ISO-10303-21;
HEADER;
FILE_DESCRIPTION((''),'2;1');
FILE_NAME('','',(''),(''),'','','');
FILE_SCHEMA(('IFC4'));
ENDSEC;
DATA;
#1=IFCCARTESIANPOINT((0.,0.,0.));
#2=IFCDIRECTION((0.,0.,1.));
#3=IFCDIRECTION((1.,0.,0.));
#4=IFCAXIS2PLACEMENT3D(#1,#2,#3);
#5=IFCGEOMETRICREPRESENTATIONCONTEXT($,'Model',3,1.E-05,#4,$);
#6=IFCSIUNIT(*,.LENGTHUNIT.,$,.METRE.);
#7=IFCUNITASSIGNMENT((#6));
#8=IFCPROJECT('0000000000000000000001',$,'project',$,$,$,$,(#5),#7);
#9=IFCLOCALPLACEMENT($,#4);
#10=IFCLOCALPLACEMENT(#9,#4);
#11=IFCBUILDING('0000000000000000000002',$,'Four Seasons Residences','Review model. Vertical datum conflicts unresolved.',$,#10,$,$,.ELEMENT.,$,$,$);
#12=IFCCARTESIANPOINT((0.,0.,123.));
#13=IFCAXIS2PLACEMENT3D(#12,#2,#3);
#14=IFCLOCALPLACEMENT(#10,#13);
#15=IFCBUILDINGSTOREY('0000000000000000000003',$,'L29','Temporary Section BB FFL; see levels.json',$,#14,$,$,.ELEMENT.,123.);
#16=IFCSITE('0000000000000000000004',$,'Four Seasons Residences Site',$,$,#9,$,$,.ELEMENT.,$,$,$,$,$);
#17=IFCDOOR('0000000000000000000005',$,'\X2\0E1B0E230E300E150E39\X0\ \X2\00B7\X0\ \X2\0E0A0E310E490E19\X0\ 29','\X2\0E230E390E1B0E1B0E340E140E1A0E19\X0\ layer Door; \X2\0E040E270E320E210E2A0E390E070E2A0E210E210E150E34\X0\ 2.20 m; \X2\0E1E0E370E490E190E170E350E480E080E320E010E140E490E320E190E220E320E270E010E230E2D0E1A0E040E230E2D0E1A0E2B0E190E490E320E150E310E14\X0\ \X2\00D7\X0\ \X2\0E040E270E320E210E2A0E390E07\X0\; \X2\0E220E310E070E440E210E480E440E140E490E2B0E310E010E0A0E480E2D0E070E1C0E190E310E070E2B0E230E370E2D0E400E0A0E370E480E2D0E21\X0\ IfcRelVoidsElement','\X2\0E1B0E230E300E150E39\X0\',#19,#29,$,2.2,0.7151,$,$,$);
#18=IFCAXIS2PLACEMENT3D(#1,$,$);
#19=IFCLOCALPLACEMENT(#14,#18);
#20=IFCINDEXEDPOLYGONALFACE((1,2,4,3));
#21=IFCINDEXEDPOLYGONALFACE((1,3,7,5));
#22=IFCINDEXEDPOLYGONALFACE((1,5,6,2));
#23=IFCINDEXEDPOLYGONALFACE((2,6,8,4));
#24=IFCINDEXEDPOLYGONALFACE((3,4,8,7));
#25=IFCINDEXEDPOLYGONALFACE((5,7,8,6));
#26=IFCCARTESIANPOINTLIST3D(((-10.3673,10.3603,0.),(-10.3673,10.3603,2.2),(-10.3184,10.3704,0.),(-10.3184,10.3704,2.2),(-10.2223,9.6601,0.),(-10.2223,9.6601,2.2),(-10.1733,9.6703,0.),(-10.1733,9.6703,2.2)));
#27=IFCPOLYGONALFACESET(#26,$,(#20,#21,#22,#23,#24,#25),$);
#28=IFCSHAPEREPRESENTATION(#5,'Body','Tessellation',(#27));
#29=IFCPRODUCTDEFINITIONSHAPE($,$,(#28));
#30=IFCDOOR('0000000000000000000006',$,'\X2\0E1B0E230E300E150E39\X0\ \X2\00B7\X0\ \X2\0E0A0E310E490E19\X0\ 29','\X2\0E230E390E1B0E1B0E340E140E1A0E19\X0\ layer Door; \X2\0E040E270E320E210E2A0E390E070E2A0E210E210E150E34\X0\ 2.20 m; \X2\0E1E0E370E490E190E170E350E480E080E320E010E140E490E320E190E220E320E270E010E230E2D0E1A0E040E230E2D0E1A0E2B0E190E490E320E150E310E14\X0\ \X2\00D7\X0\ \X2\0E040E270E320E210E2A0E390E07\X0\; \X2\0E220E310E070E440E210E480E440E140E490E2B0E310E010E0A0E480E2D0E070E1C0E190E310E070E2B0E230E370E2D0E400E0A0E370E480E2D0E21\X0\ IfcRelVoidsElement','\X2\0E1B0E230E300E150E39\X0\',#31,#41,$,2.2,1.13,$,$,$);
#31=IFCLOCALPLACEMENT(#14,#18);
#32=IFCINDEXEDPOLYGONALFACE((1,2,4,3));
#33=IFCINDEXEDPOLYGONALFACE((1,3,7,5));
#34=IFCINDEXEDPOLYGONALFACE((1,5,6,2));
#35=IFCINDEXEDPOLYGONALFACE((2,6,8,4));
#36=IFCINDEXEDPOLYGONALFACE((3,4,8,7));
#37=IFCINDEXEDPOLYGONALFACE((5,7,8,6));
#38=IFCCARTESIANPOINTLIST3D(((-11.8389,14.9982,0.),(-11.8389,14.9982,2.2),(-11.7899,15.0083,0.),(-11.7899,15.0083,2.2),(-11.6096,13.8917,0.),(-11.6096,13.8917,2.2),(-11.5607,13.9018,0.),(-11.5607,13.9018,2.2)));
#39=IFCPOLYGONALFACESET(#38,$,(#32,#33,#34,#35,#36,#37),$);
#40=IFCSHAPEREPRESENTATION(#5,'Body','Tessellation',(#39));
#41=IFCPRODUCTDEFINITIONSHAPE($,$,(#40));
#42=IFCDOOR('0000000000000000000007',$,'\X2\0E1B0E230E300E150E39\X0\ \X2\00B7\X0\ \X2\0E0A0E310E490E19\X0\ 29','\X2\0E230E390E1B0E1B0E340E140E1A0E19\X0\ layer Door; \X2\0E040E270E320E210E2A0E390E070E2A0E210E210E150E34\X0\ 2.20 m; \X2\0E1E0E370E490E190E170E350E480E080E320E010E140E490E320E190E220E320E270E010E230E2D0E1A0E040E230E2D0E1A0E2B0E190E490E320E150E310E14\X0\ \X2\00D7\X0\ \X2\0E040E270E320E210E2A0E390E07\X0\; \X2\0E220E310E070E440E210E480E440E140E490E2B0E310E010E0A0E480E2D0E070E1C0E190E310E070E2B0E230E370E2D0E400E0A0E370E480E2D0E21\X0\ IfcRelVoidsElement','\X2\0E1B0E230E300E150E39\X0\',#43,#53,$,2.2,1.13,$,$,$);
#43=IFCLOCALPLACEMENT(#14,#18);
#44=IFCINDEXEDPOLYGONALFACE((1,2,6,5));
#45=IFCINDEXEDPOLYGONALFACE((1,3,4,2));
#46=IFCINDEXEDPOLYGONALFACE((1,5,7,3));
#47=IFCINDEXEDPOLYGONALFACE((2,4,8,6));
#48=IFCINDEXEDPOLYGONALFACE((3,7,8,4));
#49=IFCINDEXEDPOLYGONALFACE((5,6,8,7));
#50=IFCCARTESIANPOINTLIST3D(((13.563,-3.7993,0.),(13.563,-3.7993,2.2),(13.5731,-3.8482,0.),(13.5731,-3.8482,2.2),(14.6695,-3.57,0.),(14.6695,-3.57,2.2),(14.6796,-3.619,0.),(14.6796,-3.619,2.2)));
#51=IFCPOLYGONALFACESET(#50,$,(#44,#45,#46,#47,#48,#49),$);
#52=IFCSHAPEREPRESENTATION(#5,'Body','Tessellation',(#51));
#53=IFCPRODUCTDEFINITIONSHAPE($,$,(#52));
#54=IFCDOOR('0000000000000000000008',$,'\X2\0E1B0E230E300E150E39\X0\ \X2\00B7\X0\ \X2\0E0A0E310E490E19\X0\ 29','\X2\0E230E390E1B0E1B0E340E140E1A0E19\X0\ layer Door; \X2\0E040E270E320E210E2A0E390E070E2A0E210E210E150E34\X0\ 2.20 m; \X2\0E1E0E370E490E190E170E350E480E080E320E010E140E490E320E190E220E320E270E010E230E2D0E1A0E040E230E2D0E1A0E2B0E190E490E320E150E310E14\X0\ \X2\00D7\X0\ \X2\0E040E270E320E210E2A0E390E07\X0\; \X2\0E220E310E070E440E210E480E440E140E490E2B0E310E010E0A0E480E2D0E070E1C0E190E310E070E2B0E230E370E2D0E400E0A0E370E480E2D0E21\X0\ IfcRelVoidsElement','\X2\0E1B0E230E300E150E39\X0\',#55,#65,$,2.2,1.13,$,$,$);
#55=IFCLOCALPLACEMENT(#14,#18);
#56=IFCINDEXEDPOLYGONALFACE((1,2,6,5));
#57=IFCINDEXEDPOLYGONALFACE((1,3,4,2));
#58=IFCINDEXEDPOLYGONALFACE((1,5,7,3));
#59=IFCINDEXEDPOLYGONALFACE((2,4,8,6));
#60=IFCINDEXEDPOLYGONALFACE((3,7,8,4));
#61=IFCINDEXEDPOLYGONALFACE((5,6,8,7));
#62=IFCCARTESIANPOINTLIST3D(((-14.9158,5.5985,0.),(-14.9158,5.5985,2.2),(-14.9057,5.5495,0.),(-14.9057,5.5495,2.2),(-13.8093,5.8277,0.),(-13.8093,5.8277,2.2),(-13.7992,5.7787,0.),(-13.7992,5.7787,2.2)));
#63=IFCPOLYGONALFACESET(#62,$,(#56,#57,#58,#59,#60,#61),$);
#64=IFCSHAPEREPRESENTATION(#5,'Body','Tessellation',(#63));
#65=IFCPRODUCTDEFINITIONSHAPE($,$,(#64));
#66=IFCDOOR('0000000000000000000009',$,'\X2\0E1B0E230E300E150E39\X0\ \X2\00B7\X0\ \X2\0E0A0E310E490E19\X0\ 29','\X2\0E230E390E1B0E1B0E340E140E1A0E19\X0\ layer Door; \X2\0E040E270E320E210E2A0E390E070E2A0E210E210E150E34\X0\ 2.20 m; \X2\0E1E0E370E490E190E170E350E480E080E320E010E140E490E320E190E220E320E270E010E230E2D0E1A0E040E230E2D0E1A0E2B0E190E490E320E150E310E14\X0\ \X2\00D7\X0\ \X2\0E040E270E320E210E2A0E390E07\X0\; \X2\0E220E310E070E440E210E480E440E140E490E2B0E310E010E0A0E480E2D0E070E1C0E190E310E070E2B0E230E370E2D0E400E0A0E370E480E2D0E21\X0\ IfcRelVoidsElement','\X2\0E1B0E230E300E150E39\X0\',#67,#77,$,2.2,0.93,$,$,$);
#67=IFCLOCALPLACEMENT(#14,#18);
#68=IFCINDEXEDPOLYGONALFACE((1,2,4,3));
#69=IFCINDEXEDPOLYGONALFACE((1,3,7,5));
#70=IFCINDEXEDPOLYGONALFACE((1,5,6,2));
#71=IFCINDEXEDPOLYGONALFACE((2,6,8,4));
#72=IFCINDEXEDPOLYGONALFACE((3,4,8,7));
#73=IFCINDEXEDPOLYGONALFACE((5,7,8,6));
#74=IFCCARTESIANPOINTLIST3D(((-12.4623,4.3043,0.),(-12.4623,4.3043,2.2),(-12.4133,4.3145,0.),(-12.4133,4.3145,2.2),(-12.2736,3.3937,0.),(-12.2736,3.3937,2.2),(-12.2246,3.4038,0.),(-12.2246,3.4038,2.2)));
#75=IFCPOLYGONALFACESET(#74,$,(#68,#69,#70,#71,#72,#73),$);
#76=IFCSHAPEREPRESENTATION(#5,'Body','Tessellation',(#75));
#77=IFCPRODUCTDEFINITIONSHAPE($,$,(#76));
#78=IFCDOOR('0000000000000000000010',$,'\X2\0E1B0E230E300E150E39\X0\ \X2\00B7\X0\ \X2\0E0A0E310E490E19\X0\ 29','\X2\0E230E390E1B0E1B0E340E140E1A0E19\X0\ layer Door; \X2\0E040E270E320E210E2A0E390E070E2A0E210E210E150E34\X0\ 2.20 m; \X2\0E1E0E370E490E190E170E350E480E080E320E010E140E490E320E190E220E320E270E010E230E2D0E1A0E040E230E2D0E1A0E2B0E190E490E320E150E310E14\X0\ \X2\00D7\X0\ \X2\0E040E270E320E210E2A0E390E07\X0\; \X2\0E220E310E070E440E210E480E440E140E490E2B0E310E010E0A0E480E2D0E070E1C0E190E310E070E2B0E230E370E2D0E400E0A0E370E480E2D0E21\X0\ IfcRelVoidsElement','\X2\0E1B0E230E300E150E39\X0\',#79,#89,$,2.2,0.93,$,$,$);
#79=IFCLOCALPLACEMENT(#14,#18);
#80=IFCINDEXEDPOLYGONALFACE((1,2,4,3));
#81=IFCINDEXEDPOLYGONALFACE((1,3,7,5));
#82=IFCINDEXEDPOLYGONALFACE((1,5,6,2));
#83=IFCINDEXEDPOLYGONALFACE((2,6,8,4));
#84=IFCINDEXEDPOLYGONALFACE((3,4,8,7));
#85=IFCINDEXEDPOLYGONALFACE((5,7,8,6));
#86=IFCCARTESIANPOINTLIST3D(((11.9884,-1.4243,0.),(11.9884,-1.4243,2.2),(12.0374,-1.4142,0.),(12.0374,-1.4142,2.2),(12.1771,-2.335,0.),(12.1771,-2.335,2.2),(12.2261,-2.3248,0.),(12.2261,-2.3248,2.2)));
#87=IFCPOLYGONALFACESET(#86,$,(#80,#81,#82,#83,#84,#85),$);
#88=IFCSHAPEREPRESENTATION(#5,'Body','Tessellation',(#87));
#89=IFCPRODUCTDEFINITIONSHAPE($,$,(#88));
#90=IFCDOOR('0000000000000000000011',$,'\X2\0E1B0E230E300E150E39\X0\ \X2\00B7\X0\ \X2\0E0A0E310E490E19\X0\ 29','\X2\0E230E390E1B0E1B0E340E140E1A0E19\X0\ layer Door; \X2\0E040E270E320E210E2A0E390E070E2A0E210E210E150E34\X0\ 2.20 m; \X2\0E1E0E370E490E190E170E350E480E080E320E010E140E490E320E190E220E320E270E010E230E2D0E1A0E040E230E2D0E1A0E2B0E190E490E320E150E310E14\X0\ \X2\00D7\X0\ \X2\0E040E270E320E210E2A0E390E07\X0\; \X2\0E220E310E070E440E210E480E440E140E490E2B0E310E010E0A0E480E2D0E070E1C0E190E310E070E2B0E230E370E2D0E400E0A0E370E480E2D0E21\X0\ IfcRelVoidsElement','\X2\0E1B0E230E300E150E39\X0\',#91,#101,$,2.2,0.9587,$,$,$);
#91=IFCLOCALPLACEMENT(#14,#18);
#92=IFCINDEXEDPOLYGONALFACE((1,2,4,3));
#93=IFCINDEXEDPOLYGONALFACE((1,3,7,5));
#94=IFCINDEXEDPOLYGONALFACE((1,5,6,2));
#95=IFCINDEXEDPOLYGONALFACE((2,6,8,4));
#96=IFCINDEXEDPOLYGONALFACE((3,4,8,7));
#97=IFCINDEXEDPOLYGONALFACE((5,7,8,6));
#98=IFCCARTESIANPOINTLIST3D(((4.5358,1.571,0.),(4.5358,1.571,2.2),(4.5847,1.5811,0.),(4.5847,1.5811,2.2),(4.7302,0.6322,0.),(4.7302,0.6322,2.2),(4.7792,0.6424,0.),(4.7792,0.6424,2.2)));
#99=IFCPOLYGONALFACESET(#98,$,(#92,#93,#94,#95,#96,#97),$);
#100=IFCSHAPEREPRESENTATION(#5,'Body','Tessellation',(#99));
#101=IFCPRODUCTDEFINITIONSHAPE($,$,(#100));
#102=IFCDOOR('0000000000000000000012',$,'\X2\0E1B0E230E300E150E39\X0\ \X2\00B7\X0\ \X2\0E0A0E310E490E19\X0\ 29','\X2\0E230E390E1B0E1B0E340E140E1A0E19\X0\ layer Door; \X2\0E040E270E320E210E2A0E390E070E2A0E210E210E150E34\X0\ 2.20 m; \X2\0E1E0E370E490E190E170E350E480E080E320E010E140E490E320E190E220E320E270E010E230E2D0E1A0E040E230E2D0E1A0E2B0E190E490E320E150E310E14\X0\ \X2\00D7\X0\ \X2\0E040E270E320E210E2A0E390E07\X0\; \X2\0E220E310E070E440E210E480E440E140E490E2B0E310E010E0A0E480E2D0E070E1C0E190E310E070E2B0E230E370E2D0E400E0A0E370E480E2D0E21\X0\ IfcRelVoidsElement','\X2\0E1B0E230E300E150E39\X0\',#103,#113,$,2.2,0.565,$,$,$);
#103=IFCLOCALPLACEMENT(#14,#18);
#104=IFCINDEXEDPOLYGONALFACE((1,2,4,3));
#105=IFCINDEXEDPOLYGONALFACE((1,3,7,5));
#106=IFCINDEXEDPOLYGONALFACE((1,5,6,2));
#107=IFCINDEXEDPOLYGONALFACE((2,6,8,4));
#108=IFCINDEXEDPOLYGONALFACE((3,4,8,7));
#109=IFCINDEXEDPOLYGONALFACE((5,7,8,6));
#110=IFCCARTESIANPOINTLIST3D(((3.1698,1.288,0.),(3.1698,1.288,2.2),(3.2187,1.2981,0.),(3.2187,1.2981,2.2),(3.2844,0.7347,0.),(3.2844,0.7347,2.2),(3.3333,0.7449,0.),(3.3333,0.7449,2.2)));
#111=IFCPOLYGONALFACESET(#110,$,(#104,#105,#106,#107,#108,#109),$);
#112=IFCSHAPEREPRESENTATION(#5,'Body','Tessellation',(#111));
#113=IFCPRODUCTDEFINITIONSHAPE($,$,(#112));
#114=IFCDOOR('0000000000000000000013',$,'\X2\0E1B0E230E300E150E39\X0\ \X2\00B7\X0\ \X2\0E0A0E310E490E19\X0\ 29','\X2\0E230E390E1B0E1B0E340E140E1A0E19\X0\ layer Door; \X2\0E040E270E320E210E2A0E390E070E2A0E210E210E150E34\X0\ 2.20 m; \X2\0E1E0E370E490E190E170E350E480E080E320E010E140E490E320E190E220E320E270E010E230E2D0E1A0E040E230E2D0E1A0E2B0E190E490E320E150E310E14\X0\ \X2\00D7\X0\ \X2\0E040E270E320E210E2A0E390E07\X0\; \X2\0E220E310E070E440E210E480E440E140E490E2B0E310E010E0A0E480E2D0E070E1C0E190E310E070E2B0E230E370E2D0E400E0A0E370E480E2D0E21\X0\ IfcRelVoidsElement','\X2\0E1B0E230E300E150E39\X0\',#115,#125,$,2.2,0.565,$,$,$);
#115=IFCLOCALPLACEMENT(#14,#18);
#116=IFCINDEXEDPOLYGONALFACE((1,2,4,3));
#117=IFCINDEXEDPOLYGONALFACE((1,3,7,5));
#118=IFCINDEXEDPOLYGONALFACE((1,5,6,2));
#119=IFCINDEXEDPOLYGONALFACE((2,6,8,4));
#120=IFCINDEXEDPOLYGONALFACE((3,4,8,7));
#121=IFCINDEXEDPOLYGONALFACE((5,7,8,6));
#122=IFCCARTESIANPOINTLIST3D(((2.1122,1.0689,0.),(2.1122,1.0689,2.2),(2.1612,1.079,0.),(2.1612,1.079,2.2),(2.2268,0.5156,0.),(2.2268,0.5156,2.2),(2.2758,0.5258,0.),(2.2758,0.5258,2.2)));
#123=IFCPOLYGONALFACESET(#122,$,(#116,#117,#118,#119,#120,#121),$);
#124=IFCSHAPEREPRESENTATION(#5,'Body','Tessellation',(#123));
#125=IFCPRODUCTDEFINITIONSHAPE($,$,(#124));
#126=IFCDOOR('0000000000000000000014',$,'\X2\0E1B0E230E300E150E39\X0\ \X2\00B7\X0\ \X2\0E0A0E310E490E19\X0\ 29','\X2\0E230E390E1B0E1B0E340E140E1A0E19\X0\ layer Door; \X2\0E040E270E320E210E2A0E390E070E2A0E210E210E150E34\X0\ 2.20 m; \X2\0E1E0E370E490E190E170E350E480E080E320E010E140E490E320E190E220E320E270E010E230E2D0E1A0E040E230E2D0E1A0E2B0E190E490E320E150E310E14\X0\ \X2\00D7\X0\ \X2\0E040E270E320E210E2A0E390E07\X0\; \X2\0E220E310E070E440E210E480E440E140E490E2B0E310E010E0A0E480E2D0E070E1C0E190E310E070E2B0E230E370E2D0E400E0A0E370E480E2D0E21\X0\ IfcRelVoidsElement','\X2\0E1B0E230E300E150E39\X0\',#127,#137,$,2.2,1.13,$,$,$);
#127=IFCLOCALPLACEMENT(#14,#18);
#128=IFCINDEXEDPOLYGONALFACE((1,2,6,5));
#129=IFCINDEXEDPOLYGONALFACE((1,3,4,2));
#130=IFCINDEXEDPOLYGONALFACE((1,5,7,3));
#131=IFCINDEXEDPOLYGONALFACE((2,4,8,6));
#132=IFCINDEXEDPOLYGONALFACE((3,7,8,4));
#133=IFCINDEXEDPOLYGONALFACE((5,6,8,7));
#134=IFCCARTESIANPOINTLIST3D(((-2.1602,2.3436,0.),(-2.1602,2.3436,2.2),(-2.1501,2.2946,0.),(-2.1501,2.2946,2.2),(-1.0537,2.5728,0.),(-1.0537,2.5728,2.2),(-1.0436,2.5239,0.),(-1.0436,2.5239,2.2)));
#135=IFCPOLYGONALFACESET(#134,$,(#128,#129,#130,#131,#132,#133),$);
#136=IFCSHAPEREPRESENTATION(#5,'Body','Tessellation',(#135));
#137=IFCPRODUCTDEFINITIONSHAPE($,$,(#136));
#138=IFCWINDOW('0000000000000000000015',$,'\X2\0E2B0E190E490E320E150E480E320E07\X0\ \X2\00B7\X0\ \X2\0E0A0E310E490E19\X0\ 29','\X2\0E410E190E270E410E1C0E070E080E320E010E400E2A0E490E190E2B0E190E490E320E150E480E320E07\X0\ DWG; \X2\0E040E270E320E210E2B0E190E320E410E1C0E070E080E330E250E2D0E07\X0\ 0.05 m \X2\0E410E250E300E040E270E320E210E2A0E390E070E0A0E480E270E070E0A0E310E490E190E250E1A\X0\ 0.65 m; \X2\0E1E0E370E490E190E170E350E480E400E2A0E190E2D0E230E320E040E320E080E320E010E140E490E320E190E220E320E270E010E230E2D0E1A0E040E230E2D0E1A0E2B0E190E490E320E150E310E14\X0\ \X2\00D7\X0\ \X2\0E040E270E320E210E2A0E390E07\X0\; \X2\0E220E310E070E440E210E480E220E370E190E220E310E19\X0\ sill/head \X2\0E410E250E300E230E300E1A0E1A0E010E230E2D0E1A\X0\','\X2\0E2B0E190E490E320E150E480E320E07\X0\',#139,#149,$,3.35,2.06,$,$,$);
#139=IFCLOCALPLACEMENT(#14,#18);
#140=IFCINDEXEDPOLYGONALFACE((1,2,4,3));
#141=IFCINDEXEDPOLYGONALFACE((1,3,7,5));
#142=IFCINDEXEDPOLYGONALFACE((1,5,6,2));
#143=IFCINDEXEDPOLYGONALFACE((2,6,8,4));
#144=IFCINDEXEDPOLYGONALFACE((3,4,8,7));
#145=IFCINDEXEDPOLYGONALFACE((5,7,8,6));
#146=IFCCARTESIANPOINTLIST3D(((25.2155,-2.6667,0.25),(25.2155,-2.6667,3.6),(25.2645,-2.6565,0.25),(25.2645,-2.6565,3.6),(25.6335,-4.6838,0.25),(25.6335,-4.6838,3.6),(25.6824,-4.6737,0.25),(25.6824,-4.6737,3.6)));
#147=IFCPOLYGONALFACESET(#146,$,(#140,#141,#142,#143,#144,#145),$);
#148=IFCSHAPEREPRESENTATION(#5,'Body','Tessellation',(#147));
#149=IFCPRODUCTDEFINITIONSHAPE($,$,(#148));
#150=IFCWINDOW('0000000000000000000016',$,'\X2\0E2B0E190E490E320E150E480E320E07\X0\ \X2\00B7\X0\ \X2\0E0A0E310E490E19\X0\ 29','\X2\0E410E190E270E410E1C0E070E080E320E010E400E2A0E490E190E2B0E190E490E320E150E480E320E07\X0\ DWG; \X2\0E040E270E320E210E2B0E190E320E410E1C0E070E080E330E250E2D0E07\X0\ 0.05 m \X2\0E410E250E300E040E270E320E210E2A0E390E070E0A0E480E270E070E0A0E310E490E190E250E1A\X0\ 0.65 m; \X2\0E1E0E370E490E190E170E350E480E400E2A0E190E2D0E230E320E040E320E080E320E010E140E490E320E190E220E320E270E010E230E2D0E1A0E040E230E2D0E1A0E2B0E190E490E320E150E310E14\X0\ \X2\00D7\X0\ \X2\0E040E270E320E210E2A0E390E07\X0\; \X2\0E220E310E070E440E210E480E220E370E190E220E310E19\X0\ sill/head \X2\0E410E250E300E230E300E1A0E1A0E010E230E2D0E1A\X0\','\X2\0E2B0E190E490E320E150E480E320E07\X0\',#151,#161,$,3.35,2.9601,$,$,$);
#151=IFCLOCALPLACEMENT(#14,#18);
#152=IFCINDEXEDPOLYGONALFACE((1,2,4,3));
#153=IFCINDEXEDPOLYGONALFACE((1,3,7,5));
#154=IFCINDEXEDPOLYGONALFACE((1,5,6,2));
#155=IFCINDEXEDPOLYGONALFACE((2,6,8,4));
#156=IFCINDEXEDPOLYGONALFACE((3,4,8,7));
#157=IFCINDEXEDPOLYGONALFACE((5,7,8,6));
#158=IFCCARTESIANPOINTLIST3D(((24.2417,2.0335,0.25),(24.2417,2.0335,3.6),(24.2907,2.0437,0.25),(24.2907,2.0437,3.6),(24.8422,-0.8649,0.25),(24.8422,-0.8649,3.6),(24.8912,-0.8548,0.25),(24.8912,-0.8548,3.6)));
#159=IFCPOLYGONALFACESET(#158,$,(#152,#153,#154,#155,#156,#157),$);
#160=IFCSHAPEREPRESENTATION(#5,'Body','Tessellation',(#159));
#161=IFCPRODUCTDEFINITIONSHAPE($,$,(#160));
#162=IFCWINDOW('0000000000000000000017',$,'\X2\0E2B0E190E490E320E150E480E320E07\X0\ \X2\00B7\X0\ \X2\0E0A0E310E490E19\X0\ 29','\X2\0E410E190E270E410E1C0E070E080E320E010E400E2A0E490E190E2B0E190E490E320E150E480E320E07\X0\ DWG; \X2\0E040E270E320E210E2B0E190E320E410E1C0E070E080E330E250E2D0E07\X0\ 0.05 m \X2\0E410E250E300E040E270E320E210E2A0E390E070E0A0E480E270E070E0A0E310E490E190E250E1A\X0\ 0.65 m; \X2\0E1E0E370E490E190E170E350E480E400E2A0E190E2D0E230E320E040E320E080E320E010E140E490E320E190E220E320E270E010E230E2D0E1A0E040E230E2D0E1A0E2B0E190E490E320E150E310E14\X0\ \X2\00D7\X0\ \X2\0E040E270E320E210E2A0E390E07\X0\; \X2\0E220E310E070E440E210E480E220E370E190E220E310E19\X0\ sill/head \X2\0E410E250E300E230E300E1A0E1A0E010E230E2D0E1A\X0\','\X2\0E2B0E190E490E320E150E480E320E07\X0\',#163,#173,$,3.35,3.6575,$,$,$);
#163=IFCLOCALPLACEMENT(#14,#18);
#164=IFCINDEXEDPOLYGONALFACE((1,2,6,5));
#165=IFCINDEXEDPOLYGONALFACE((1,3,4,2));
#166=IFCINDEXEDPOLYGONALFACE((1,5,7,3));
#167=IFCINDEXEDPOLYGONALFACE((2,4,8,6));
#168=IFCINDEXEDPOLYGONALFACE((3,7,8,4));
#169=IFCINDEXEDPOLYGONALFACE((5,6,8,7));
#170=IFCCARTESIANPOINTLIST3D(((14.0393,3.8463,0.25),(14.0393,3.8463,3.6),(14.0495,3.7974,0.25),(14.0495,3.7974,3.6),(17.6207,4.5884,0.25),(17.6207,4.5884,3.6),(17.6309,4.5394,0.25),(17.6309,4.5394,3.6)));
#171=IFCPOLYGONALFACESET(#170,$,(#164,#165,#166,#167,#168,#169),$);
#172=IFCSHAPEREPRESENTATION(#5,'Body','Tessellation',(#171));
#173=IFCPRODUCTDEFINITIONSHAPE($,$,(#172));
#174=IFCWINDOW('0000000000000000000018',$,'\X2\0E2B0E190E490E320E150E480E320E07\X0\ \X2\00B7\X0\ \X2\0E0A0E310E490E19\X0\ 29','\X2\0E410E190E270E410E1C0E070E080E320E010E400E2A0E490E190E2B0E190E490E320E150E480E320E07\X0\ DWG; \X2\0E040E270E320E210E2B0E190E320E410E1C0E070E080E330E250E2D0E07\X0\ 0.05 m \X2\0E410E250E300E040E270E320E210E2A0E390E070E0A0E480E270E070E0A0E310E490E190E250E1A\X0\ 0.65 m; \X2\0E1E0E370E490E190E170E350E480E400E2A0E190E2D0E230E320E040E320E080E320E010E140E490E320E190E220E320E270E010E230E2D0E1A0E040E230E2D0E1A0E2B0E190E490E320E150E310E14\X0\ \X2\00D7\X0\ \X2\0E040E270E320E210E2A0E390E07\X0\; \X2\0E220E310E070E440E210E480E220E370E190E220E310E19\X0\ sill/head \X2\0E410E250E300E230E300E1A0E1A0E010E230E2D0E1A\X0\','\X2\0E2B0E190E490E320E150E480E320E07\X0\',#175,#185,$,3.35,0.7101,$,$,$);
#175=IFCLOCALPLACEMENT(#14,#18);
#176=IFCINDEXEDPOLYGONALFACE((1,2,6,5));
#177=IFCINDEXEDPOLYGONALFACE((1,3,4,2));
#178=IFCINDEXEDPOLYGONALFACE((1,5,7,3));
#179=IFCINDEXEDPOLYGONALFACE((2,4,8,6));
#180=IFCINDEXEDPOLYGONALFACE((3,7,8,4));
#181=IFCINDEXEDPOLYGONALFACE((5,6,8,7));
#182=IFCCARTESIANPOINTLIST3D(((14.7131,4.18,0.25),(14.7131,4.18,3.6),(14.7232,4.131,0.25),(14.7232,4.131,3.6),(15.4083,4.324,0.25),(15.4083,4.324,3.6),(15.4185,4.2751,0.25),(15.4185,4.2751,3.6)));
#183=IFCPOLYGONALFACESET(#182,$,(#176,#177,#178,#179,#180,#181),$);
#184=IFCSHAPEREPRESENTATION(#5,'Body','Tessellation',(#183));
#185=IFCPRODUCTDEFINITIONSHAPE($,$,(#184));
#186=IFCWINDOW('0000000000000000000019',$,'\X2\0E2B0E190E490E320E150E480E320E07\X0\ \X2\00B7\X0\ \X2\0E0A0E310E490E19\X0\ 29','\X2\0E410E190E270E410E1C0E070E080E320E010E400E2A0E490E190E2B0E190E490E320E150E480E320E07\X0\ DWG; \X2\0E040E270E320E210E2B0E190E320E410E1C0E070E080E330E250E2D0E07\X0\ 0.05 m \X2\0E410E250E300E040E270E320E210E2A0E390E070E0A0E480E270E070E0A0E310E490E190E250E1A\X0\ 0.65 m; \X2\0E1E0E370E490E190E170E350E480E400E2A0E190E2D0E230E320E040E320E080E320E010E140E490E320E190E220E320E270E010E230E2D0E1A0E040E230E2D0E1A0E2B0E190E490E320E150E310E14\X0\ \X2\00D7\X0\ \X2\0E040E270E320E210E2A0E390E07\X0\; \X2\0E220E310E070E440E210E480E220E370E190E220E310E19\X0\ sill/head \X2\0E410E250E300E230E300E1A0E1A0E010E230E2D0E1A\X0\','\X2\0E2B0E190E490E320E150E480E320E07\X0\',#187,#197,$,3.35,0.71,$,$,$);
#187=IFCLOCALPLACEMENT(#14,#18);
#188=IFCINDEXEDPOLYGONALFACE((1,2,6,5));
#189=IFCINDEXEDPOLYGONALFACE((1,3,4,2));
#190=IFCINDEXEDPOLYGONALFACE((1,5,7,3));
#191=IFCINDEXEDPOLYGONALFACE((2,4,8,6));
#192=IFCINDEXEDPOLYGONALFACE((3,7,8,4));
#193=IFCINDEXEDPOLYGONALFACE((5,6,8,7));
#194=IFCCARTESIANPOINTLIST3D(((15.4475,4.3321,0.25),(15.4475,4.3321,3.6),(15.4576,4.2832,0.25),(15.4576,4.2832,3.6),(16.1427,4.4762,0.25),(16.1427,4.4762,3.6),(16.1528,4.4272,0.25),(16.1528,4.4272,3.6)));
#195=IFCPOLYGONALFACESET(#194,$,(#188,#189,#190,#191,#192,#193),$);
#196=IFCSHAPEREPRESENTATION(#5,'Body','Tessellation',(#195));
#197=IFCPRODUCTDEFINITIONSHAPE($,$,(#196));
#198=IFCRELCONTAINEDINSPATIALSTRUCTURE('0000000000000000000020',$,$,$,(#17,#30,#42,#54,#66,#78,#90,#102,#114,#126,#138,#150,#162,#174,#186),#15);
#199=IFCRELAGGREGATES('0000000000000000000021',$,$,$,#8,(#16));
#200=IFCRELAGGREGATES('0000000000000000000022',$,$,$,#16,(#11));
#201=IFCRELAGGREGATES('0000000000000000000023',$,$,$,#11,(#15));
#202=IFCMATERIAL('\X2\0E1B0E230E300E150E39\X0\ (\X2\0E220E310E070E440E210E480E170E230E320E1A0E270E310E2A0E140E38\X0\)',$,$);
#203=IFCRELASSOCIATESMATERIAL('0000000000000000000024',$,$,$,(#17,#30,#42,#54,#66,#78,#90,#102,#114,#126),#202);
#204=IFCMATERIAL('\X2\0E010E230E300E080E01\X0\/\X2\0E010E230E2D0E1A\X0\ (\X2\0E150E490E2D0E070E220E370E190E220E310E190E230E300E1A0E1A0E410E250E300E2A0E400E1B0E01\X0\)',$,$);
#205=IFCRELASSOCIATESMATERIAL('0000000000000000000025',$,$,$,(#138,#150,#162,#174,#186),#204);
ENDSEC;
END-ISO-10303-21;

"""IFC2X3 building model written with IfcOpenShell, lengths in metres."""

from ifc_helpers import new_model, si_unit, frame, origin_with_axes, place, context, project, spatial, polyline, outline, extrude, material, element, save


model = new_model("IFC2X3")

# Units and contexts
model_context = context("Model", 3, precision=1e-05, world=origin_with_axes())
ifc_project = project(units=[si_unit("LENGTHUNIT", "METRE")], contexts=[model_context])

# Site, building, storey
site_placement = place(None, origin_with_axes())
site = spatial("IfcSite", under=ifc_project, at=site_placement, Name="Four Seasons Residences Site", CompositionType="ELEMENT")
building_placement = place(site_placement, origin_with_axes())
building = spatial("IfcBuilding", under=site, at=building_placement, Name="Four Seasons Residences", Description="Review model. Vertical datum conflicts unresolved.", CompositionType="ELEMENT")
storey_placement = place(building_placement, frame((0.0, 0.0, 123.0), z_axis=(0.0, 0.0, 1.0), x_axis=(1.0, 0.0, 0.0)))
storey = spatial("IfcBuildingStorey", under=building, at=storey_placement, Name="L29", Description="Temporary Section BB FFL; see levels.json", CompositionType="ELEMENT", Elevation=123.0)

# Doors
ifc_material_1 = material(Name="ประตู (ยังไม่ทราบวัสดุ)")
door_1_placement = place(storey_placement, origin_with_axes())
element("IfcDoor", 1, at=door_1_placement, inside=storey, material=ifc_material_1, Name="ประตู · ชั้น 29", Description="รูปปิดบน layer Door; ความสูงสมมติ 2.20 m; พื้นที่จากด้านยาวกรอบครอบหน้าตัด × ความสูง; ยังไม่ได้หักช่องผนังหรือเชื่อม IfcRelVoidsElement", ObjectType="ประตู", OverallHeight=2.2, OverallWidth=0.7151, context=model_context, shape_type="SweptSolid", body=[
    extrude(outline(polyline([(-10.3184, 10.3704), (-10.1733, 9.6703), (-10.2223, 9.6601), (-10.3673, 10.3603), (-10.3184, 10.3704)])), origin_with_axes(), (0.0, 0.0, 1.0), 2.2),
])
door_2_placement = place(storey_placement, origin_with_axes())
element("IfcDoor", 2, at=door_2_placement, inside=storey, material=ifc_material_1, Name="ประตู · ชั้น 29", Description="รูปปิดบน layer Door; ความสูงสมมติ 2.20 m; พื้นที่จากด้านยาวกรอบครอบหน้าตัด × ความสูง; ยังไม่ได้หักช่องผนังหรือเชื่อม IfcRelVoidsElement", ObjectType="ประตู", OverallHeight=2.2, OverallWidth=1.13, context=model_context, shape_type="SweptSolid", body=[
    extrude(outline(polyline([(-11.7899, 15.0083), (-11.5607, 13.9018), (-11.6096, 13.8917), (-11.8389, 14.9982), (-11.7899, 15.0083)])), origin_with_axes(), (0.0, 0.0, 1.0), 2.2),
])
door_3_placement = place(storey_placement, origin_with_axes())
element("IfcDoor", 3, at=door_3_placement, inside=storey, material=ifc_material_1, Name="ประตู · ชั้น 29", Description="รูปปิดบน layer Door; ความสูงสมมติ 2.20 m; พื้นที่จากด้านยาวกรอบครอบหน้าตัด × ความสูง; ยังไม่ได้หักช่องผนังหรือเชื่อม IfcRelVoidsElement", ObjectType="ประตู", OverallHeight=2.2, OverallWidth=1.13, context=model_context, shape_type="SweptSolid", body=[
    extrude(outline(polyline([(14.6796, -3.619), (13.5731, -3.8482), (13.563, -3.7993), (14.6695, -3.57), (14.6796, -3.619)])), origin_with_axes(), (0.0, 0.0, 1.0), 2.2),
])
door_4_placement = place(storey_placement, origin_with_axes())
element("IfcDoor", 4, at=door_4_placement, inside=storey, material=ifc_material_1, Name="ประตู · ชั้น 29", Description="รูปปิดบน layer Door; ความสูงสมมติ 2.20 m; พื้นที่จากด้านยาวกรอบครอบหน้าตัด × ความสูง; ยังไม่ได้หักช่องผนังหรือเชื่อม IfcRelVoidsElement", ObjectType="ประตู", OverallHeight=2.2, OverallWidth=1.13, context=model_context, shape_type="SweptSolid", body=[
    extrude(outline(polyline([(-14.9158, 5.5985), (-13.8093, 5.8277), (-13.7992, 5.7787), (-14.9057, 5.5495), (-14.9158, 5.5985)])), origin_with_axes(), (0.0, 0.0, 1.0), 2.2),
])
door_5_placement = place(storey_placement, origin_with_axes())
element("IfcDoor", 5, at=door_5_placement, inside=storey, material=ifc_material_1, Name="ประตู · ชั้น 29", Description="รูปปิดบน layer Door; ความสูงสมมติ 2.20 m; พื้นที่จากด้านยาวกรอบครอบหน้าตัด × ความสูง; ยังไม่ได้หักช่องผนังหรือเชื่อม IfcRelVoidsElement", ObjectType="ประตู", OverallHeight=2.2, OverallWidth=0.93, context=model_context, shape_type="SweptSolid", body=[
    extrude(outline(polyline([(-12.4623, 4.3043), (-12.4133, 4.3145), (-12.2246, 3.4038), (-12.2736, 3.3937), (-12.4623, 4.3043)])), origin_with_axes(), (0.0, 0.0, 1.0), 2.2),
])
door_6_placement = place(storey_placement, origin_with_axes())
element("IfcDoor", 6, at=door_6_placement, inside=storey, material=ifc_material_1, Name="ประตู · ชั้น 29", Description="รูปปิดบน layer Door; ความสูงสมมติ 2.20 m; พื้นที่จากด้านยาวกรอบครอบหน้าตัด × ความสูง; ยังไม่ได้หักช่องผนังหรือเชื่อม IfcRelVoidsElement", ObjectType="ประตู", OverallHeight=2.2, OverallWidth=0.93, context=model_context, shape_type="SweptSolid", body=[
    extrude(outline(polyline([(12.2261, -2.3248), (12.1771, -2.335), (11.9884, -1.4243), (12.0374, -1.4142), (12.2261, -2.3248)])), origin_with_axes(), (0.0, 0.0, 1.0), 2.2),
])
door_7_placement = place(storey_placement, origin_with_axes())
element("IfcDoor", 7, at=door_7_placement, inside=storey, material=ifc_material_1, Name="ประตู · ชั้น 29", Description="รูปปิดบน layer Door; ความสูงสมมติ 2.20 m; พื้นที่จากด้านยาวกรอบครอบหน้าตัด × ความสูง; ยังไม่ได้หักช่องผนังหรือเชื่อม IfcRelVoidsElement", ObjectType="ประตู", OverallHeight=2.2, OverallWidth=0.9587, context=model_context, shape_type="SweptSolid", body=[
    extrude(outline(polyline([(4.5358, 1.571), (4.5847, 1.5811), (4.7792, 0.6424), (4.7302, 0.6322), (4.5358, 1.571)])), origin_with_axes(), (0.0, 0.0, 1.0), 2.2),
])
door_8_placement = place(storey_placement, origin_with_axes())
element("IfcDoor", 8, at=door_8_placement, inside=storey, material=ifc_material_1, Name="ประตู · ชั้น 29", Description="รูปปิดบน layer Door; ความสูงสมมติ 2.20 m; พื้นที่จากด้านยาวกรอบครอบหน้าตัด × ความสูง; ยังไม่ได้หักช่องผนังหรือเชื่อม IfcRelVoidsElement", ObjectType="ประตู", OverallHeight=2.2, OverallWidth=0.565, context=model_context, shape_type="SweptSolid", body=[
    extrude(outline(polyline([(3.3333, 0.7449), (3.2187, 1.2981), (3.1698, 1.288), (3.2844, 0.7347), (3.3333, 0.7449)])), origin_with_axes(), (0.0, 0.0, 1.0), 2.2),
])
door_9_placement = place(storey_placement, origin_with_axes())
element("IfcDoor", 9, at=door_9_placement, inside=storey, material=ifc_material_1, Name="ประตู · ชั้น 29", Description="รูปปิดบน layer Door; ความสูงสมมติ 2.20 m; พื้นที่จากด้านยาวกรอบครอบหน้าตัด × ความสูง; ยังไม่ได้หักช่องผนังหรือเชื่อม IfcRelVoidsElement", ObjectType="ประตู", OverallHeight=2.2, OverallWidth=0.565, context=model_context, shape_type="SweptSolid", body=[
    extrude(outline(polyline([(2.2268, 0.5156), (2.1122, 1.0689), (2.1612, 1.079), (2.2758, 0.5258), (2.2268, 0.5156)])), origin_with_axes(), (0.0, 0.0, 1.0), 2.2),
])
door_10_placement = place(storey_placement, origin_with_axes())
element("IfcDoor", 10, at=door_10_placement, inside=storey, material=ifc_material_1, Name="ประตู · ชั้น 29", Description="รูปปิดบน layer Door; ความสูงสมมติ 2.20 m; พื้นที่จากด้านยาวกรอบครอบหน้าตัด × ความสูง; ยังไม่ได้หักช่องผนังหรือเชื่อม IfcRelVoidsElement", ObjectType="ประตู", OverallHeight=2.2, OverallWidth=1.13, context=model_context, shape_type="SweptSolid", body=[
    extrude(outline(polyline([(-1.0537, 2.5728), (-2.1602, 2.3436), (-2.1501, 2.2946), (-1.0436, 2.5239), (-1.0537, 2.5728)])), origin_with_axes(), (0.0, 0.0, 1.0), 2.2),
])

# Windows
ifc_material_2 = material(Name="กระจก/กรอบ (ต้องยืนยันระบบและสเปก)")
window_1_placement = place(storey_placement, origin_with_axes())
element("IfcWindow", 11, at=window_1_placement, inside=storey, material=ifc_material_2, Name="หน้าต่าง · ชั้น 29", Description="แนวแผงจากเส้นหน้าต่าง DWG; ความหนาแผงจำลอง 0.05 m และความสูงช่วงชั้นลบ 0.65 m; พื้นที่เสนอราคาจากด้านยาวกรอบครอบหน้าตัด × ความสูง; ยังไม่ยืนยัน sill/head และระบบกรอบ", ObjectType="หน้าต่าง", OverallHeight=3.35, OverallWidth=2.06, context=model_context, shape_type="SweptSolid", body=[
    extrude(outline(polyline([(25.2155, -2.6667), (25.2645, -2.6565), (25.6824, -4.6737), (25.6335, -4.6838), (25.2155, -2.6667)])), frame((0.0, 0.0, 0.25), z_axis=(0.0, 0.0, 1.0), x_axis=(1.0, 0.0, 0.0)), (0.0, 0.0, 1.0), 3.35),
])
window_2_placement = place(storey_placement, origin_with_axes())
element("IfcWindow", 12, at=window_2_placement, inside=storey, material=ifc_material_2, Name="หน้าต่าง · ชั้น 29", Description="แนวแผงจากเส้นหน้าต่าง DWG; ความหนาแผงจำลอง 0.05 m และความสูงช่วงชั้นลบ 0.65 m; พื้นที่เสนอราคาจากด้านยาวกรอบครอบหน้าตัด × ความสูง; ยังไม่ยืนยัน sill/head และระบบกรอบ", ObjectType="หน้าต่าง", OverallHeight=3.35, OverallWidth=2.9601, context=model_context, shape_type="SweptSolid", body=[
    extrude(outline(polyline([(24.2417, 2.0335), (24.2907, 2.0437), (24.8912, -0.8548), (24.8422, -0.8649), (24.2417, 2.0335)])), frame((0.0, 0.0, 0.25), z_axis=(0.0, 0.0, 1.0), x_axis=(1.0, 0.0, 0.0)), (0.0, 0.0, 1.0), 3.35),
])
window_3_placement = place(storey_placement, origin_with_axes())
element("IfcWindow", 13, at=window_3_placement, inside=storey, material=ifc_material_2, Name="หน้าต่าง · ชั้น 29", Description="แนวแผงจากเส้นหน้าต่าง DWG; ความหนาแผงจำลอง 0.05 m และความสูงช่วงชั้นลบ 0.65 m; พื้นที่เสนอราคาจากด้านยาวกรอบครอบหน้าตัด × ความสูง; ยังไม่ยืนยัน sill/head และระบบกรอบ", ObjectType="หน้าต่าง", OverallHeight=3.35, OverallWidth=3.6575, context=model_context, shape_type="SweptSolid", body=[
    extrude(outline(polyline([(14.0495, 3.7974), (14.0393, 3.8463), (17.6207, 4.5884), (17.6309, 4.5394), (14.0495, 3.7974)])), frame((0.0, 0.0, 0.25), z_axis=(0.0, 0.0, 1.0), x_axis=(1.0, 0.0, 0.0)), (0.0, 0.0, 1.0), 3.35),
])
window_4_placement = place(storey_placement, origin_with_axes())
element("IfcWindow", 14, at=window_4_placement, inside=storey, material=ifc_material_2, Name="หน้าต่าง · ชั้น 29", Description="แนวแผงจากเส้นหน้าต่าง DWG; ความหนาแผงจำลอง 0.05 m และความสูงช่วงชั้นลบ 0.65 m; พื้นที่เสนอราคาจากด้านยาวกรอบครอบหน้าตัด × ความสูง; ยังไม่ยืนยัน sill/head และระบบกรอบ", ObjectType="หน้าต่าง", OverallHeight=3.35, OverallWidth=0.7101, context=model_context, shape_type="SweptSolid", body=[
    extrude(outline(polyline([(14.7232, 4.131), (14.7131, 4.18), (15.4083, 4.324), (15.4185, 4.2751), (14.7232, 4.131)])), frame((0.0, 0.0, 0.25), z_axis=(0.0, 0.0, 1.0), x_axis=(1.0, 0.0, 0.0)), (0.0, 0.0, 1.0), 3.35),
])
window_5_placement = place(storey_placement, origin_with_axes())
element("IfcWindow", 15, at=window_5_placement, inside=storey, material=ifc_material_2, Name="หน้าต่าง · ชั้น 29", Description="แนวแผงจากเส้นหน้าต่าง DWG; ความหนาแผงจำลอง 0.05 m และความสูงช่วงชั้นลบ 0.65 m; พื้นที่เสนอราคาจากด้านยาวกรอบครอบหน้าตัด × ความสูง; ยังไม่ยืนยัน sill/head และระบบกรอบ", ObjectType="หน้าต่าง", OverallHeight=3.35, OverallWidth=0.71, context=model_context, shape_type="SweptSolid", body=[
    extrude(outline(polyline([(16.1427, 4.4762), (16.1528, 4.4272), (15.4576, 4.2832), (15.4475, 4.3321), (16.1427, 4.4762)])), frame((0.0, 0.0, 0.25), z_axis=(0.0, 0.0, 1.0), x_axis=(1.0, 0.0, 0.0)), (0.0, 0.0, 1.0), 3.35),
])

save(model, "model.ifc")
